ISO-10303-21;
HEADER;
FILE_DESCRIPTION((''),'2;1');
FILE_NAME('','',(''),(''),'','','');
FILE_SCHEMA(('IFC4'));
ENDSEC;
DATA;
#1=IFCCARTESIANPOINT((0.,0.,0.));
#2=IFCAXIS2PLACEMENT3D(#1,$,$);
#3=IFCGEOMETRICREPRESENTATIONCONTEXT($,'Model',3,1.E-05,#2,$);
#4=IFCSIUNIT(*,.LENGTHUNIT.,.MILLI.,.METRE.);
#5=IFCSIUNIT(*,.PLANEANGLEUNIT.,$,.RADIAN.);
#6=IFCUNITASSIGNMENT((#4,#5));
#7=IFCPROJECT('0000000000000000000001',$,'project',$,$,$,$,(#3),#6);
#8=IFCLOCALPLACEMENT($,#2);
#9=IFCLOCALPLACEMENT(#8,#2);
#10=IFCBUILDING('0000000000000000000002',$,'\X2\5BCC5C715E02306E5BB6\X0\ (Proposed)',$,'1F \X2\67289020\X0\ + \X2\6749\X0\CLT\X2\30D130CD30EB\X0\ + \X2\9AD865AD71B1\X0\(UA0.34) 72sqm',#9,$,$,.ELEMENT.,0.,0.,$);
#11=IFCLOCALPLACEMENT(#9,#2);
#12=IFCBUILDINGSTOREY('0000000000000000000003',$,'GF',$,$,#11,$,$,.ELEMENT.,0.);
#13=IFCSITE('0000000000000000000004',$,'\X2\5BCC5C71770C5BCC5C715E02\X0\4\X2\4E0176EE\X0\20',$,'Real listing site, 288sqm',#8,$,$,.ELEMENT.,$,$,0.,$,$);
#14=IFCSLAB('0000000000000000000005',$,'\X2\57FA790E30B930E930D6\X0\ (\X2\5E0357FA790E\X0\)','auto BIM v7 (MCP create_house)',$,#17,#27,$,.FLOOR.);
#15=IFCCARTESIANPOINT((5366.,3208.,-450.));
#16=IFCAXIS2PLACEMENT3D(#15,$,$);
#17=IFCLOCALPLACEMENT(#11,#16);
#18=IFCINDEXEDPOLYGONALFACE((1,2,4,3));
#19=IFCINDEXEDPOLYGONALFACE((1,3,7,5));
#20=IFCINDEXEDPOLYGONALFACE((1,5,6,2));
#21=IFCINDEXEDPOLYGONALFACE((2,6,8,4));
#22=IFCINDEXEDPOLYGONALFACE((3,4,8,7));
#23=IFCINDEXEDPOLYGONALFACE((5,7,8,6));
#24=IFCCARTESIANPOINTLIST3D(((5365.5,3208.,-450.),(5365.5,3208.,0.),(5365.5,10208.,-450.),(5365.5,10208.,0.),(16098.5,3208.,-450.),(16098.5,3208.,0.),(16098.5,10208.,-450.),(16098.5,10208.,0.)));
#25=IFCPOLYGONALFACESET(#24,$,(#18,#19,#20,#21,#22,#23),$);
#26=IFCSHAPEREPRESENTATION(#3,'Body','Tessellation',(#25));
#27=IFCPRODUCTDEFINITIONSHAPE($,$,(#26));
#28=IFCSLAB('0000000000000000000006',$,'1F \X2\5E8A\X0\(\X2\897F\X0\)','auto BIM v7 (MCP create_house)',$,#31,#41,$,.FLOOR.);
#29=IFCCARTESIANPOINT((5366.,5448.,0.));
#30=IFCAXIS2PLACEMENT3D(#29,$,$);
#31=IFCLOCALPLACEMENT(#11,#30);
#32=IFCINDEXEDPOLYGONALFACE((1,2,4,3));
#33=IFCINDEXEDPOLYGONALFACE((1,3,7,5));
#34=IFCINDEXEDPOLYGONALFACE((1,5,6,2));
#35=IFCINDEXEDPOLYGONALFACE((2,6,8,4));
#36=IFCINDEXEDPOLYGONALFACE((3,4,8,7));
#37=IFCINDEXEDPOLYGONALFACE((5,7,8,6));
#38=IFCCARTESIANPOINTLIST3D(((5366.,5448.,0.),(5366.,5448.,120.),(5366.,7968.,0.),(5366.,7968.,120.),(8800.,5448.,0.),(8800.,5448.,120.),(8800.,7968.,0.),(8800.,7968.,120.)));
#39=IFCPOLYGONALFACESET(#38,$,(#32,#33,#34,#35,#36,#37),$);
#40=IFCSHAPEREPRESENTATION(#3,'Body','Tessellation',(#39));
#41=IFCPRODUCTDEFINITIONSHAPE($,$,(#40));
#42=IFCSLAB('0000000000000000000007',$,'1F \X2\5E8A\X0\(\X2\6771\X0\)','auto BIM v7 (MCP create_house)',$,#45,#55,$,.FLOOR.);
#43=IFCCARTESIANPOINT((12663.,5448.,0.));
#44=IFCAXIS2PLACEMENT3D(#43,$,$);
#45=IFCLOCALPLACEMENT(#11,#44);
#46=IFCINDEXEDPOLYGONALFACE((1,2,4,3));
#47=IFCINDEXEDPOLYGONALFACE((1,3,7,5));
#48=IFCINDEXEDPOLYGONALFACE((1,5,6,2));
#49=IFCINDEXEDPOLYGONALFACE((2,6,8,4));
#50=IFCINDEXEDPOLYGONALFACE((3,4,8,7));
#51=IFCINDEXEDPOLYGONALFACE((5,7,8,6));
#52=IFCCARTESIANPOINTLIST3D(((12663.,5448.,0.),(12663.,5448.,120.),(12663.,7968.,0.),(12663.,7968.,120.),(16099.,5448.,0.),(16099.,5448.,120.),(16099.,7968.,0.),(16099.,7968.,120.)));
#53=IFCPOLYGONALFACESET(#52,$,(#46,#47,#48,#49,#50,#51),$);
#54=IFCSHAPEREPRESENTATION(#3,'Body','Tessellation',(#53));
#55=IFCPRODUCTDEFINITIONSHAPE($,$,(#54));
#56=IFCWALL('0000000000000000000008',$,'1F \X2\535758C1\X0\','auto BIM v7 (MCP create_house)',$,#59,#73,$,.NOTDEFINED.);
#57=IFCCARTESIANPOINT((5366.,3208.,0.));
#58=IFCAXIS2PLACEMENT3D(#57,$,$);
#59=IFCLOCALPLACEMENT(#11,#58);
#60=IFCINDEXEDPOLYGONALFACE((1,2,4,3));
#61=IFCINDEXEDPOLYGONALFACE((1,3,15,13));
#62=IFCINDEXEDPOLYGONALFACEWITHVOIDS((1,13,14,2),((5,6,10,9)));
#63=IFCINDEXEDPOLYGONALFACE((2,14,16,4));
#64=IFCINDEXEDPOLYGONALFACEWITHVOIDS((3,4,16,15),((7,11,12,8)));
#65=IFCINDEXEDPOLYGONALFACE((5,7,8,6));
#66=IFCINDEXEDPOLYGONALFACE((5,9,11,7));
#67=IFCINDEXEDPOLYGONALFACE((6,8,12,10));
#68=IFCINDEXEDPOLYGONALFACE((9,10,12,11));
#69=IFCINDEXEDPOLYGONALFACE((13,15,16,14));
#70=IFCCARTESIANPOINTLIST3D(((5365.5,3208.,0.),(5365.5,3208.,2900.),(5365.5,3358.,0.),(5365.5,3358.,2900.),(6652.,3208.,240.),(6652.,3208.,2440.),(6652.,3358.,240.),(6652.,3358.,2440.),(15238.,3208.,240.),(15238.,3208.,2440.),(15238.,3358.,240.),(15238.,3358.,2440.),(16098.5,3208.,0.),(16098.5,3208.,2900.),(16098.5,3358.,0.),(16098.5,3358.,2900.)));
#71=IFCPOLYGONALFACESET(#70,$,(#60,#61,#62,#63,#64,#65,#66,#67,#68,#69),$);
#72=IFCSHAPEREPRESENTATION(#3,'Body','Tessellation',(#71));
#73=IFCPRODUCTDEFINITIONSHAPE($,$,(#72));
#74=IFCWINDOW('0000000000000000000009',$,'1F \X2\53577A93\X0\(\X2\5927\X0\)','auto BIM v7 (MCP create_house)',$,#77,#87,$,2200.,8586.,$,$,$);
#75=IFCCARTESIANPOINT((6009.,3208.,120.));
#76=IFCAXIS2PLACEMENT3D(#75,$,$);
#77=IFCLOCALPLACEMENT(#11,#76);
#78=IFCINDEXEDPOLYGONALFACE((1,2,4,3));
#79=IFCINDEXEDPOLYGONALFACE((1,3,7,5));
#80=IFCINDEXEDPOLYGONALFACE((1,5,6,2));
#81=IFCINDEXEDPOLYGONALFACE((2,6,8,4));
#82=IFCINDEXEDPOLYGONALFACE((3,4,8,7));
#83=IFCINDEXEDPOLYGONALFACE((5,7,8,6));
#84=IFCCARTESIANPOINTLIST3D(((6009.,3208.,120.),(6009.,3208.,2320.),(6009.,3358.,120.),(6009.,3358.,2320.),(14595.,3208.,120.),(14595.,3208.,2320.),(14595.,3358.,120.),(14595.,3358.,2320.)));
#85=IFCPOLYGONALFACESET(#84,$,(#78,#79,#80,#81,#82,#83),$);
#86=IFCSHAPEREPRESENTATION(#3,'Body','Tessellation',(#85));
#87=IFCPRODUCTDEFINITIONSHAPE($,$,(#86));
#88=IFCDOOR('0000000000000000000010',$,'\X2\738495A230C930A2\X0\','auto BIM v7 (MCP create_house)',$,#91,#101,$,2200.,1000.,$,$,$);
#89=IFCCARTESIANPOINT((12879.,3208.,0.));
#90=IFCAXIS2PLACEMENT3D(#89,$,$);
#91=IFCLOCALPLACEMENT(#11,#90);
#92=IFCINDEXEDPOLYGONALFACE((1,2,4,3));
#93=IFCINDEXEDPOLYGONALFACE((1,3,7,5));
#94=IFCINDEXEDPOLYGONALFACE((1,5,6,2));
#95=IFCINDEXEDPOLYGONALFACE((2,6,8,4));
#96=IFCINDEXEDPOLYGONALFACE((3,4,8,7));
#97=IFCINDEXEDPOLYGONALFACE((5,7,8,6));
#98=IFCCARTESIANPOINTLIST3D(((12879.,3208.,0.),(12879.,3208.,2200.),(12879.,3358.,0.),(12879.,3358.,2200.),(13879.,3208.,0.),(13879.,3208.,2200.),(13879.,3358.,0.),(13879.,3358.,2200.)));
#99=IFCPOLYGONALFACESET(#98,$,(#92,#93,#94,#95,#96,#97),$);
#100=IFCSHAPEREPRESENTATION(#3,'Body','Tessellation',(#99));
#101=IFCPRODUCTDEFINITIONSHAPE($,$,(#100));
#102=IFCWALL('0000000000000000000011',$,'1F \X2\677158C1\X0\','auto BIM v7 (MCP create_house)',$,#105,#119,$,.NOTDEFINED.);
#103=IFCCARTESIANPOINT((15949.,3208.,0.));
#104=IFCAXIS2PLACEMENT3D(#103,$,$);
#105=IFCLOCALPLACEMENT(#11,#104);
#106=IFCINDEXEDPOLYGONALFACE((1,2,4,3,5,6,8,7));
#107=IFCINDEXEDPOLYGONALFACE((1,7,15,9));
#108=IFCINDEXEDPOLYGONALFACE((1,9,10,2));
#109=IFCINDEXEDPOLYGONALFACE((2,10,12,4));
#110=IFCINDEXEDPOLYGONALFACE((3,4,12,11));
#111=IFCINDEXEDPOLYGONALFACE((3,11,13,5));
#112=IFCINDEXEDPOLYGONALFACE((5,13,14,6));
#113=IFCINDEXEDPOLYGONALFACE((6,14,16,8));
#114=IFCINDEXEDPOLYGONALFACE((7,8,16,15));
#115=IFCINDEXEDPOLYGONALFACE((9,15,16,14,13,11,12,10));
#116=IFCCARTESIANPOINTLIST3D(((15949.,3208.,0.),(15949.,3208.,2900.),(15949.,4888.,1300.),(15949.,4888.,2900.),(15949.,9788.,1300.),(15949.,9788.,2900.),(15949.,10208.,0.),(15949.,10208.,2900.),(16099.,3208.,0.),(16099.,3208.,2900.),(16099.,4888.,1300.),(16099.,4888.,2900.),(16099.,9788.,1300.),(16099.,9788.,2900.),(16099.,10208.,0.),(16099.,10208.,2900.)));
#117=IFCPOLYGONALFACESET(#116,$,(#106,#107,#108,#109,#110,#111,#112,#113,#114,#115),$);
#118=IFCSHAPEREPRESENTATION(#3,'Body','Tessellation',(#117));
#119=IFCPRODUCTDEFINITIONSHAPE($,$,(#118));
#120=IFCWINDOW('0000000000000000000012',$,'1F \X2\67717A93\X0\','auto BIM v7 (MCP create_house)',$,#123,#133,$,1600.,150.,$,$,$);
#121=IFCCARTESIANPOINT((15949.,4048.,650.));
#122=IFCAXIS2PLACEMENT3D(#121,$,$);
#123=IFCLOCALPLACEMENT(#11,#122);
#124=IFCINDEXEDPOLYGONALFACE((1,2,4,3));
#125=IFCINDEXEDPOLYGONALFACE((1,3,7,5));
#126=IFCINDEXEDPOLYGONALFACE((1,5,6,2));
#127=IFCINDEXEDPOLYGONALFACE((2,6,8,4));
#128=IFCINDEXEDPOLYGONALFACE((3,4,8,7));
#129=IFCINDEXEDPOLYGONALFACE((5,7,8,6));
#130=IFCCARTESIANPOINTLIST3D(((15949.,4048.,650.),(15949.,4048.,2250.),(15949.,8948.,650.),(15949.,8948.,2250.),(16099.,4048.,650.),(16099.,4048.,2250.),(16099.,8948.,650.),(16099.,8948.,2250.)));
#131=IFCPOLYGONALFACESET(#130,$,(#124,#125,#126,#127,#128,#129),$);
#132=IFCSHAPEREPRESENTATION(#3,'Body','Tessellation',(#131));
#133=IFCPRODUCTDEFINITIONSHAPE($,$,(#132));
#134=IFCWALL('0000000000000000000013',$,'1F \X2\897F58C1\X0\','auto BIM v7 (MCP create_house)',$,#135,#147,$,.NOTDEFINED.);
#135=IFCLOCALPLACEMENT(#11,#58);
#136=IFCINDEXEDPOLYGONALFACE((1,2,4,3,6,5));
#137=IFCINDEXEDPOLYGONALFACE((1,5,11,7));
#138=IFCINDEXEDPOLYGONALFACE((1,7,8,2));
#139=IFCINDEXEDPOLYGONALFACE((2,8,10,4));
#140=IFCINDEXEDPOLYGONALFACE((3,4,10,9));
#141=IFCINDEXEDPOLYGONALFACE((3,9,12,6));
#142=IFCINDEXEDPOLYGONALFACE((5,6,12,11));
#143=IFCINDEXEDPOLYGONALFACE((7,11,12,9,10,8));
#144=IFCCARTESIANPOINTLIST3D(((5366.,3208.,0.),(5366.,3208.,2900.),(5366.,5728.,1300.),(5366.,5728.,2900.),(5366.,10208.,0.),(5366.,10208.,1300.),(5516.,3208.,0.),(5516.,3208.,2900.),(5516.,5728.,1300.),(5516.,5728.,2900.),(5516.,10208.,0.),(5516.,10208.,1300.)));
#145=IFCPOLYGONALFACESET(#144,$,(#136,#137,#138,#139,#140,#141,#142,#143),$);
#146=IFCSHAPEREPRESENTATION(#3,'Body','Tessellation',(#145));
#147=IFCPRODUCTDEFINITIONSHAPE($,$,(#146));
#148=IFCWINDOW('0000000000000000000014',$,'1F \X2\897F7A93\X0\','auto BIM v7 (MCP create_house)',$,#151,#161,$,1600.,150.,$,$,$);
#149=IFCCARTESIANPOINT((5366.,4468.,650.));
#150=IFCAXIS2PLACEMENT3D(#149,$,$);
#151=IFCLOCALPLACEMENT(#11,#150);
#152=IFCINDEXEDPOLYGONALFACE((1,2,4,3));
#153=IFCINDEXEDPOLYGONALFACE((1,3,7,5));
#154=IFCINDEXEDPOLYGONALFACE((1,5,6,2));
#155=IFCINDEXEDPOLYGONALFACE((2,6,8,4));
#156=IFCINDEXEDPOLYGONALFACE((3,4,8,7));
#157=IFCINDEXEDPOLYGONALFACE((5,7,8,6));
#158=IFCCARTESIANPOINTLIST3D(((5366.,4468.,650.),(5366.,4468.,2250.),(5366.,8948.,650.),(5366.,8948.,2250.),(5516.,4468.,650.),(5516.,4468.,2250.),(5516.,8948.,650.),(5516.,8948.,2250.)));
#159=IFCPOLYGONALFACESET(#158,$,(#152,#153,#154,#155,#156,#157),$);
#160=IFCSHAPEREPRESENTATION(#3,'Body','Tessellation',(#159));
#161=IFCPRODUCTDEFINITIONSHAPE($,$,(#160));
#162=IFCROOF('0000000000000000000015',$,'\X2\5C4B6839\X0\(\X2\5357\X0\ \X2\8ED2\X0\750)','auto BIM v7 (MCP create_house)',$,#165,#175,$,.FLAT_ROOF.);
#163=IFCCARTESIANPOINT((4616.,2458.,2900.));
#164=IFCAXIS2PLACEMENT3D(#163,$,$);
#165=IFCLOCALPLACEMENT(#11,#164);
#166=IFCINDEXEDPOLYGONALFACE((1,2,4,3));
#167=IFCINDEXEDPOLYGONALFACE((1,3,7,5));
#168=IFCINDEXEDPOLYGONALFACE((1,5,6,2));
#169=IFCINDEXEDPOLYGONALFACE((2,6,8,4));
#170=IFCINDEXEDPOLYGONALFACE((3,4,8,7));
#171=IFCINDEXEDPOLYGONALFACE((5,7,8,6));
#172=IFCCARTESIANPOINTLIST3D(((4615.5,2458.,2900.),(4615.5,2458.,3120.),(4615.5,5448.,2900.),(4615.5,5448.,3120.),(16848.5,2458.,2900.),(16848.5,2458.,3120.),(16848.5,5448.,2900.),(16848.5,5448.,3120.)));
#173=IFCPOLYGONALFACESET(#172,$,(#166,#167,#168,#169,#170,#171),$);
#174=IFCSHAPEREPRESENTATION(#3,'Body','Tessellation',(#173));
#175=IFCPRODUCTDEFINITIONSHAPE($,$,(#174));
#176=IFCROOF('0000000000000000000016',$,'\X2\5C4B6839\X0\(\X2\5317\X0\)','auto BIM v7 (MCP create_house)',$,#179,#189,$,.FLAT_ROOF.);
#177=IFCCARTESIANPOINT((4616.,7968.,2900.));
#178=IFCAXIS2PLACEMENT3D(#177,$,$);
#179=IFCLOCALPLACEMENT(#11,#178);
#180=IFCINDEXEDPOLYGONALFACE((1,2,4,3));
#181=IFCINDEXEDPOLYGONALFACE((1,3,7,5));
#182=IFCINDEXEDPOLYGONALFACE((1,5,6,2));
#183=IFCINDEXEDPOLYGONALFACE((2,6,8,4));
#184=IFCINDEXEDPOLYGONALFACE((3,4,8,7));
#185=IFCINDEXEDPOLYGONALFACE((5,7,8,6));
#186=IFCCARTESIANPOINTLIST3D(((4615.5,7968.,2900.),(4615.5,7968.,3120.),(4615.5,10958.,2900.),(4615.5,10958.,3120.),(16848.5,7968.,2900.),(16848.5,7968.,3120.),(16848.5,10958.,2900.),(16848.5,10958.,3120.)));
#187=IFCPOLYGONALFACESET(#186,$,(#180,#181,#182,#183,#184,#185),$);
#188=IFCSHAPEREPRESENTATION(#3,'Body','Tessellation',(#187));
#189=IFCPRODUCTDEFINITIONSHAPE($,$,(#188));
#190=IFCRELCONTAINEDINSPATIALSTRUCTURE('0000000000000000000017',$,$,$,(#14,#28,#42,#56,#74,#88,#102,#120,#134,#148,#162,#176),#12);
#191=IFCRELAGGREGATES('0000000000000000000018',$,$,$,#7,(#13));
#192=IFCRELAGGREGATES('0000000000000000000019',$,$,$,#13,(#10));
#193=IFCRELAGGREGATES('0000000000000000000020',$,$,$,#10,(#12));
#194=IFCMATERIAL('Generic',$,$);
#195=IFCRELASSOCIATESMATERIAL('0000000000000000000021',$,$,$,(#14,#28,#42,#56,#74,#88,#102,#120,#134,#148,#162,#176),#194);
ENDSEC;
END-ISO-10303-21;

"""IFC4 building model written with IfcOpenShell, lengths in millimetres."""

from ifc_helpers import new_model, si_unit, frame, frame_2d, origin, place, context, project, spatial, rectangle, extrude, material, element, fill, save


model = new_model("IFC4")

# Units and contexts
model_context = context("Model", 3, precision=1e-05, world=origin())
ifc_project = project(units=[si_unit("LENGTHUNIT", "METRE", prefix="MILLI"), si_unit("PLANEANGLEUNIT", "RADIAN")], contexts=[model_context])

# Site, building, storey
site_placement = place(None, origin())
site = spatial("IfcSite", under=ifc_project, at=site_placement, Name="富山県富山市4丁目20", ObjectType="Real listing site, 288sqm", CompositionType="ELEMENT", RefElevation=0.0)
building_placement = place(site_placement, origin())
building = spatial("IfcBuilding", under=site, at=building_placement, Name="富山市の家 (Proposed)", ObjectType="1F 木造 + 杉CLTパネル + 高断熱(UA0.34) 72sqm", CompositionType="ELEMENT", ElevationOfRefHeight=0.0, ElevationOfTerrain=0.0)
storey_placement = place(building_placement, origin())
storey = spatial("IfcBuildingStorey", under=building, at=storey_placement, Name="GF", CompositionType="ELEMENT", Elevation=0.0)

# Slabs
ifc_material = material(Name="Generic")
slab_1_placement = place(storey_placement, frame((5366.0, 3208.0, -450.0)))
element("IfcSlab", 1, at=slab_1_placement, inside=storey, material=ifc_material, Name="基礎スラブ (布基礎)", Description="auto BIM v7 (MCP create_house)", PredefinedType="FLOOR", context=model_context, shape_type="SweptSolid", body=[
    extrude(rectangle(XDim=10733.0, YDim=7000.0, at=frame_2d((5366.0, 3500.0))), frame((5366.0, 3208.0, -450.0)), (0.0, 0.0, 1.0), 450.0),
])
slab_2_placement = place(storey_placement, frame((5366.0, 5448.0, 0.0)))
element("IfcSlab", 2, at=slab_2_placement, inside=storey, material=ifc_material, Name="1F 床(西)", Description="auto BIM v7 (MCP create_house)", PredefinedType="FLOOR", context=model_context, shape_type="SweptSolid", body=[
    extrude(rectangle(XDim=3434.0, YDim=2520.0, at=frame_2d((1717.0, 1260.0))), frame((5366.0, 5448.0, 0.0)), (0.0, 0.0, 1.0), 120.0),
])
slab_3_placement = place(storey_placement, frame((12663.0, 5448.0, 0.0)))
element("IfcSlab", 3, at=slab_3_placement, inside=storey, material=ifc_material, Name="1F 床(東)", Description="auto BIM v7 (MCP create_house)", PredefinedType="FLOOR", context=model_context, shape_type="SweptSolid", body=[
    extrude(rectangle(XDim=3436.0, YDim=2520.0, at=frame_2d((1718.0, 1260.0))), frame((12663.0, 5448.0, 0.0)), (0.0, 0.0, 1.0), 120.0),
])

# Wall, openings, window, door
wall_1_placement = place(storey_placement, frame((5366.0, 3208.0, 0.0)))
wall_1 = element("IfcWall", 4, at=wall_1_placement, inside=storey, material=ifc_material, Name="1F 南壁", Description="auto BIM v7 (MCP create_house)", PredefinedType="NOTDEFINED", context=model_context, shape_type="SweptSolid", body=[
    extrude(rectangle(XDim=10733.0, YDim=150.0, at=frame_2d((5366.0, 75.0))), frame((5366.0, 3208.0, 0.0)), (0.0, 0.0, 1.0), 2900.0),
])
opening_1_placement = place(storey_placement, frame((6009.0, 3208.0, 120.0)))
opening_1 = element("IfcOpeningElement", 5, at=opening_1_placement, cuts=wall_1, PredefinedType="NOTDEFINED", context=model_context, shape_type="SweptSolid", body=[
    extrude(rectangle(XDim=8586.0, YDim=150.0, at=frame_2d((4293.0, 75.0))), frame((6009.0, 3208.0, 120.0)), (0.0, 0.0, 1.0), 2200.0),
])
opening_2_placement = place(storey_placement, frame((12879.0, 3208.0, 0.0)))
opening_2 = element("IfcOpeningElement", 6, at=opening_2_placement, cuts=wall_1, PredefinedType="NOTDEFINED", context=model_context, shape_type="SweptSolid", body=[
    extrude(rectangle(XDim=1000.0, YDim=150.0, at=frame_2d((500.0, 75.0))), frame((12879.0, 3208.0, 0.0)), (0.0, 0.0, 1.0), 2200.0),
])
window_1_placement = place(storey_placement, frame((6009.0, 3208.0, 120.0)))
window_1 = element("IfcWindow", 7, at=window_1_placement, inside=storey, material=ifc_material, Name="1F 南窓(大)", Description="auto BIM v7 (MCP create_house)", OverallHeight=2200.0, OverallWidth=8586.0, context=model_context, shape_type="SweptSolid", body=[
    extrude(rectangle(XDim=8586.0, YDim=150.0, at=frame_2d((4293.0, 75.0))), frame((6009.0, 3208.0, 120.0)), (0.0, 0.0, 1.0), 2200.0),
])
fill(opening_1, window_1)
door_placement = place(storey_placement, frame((12879.0, 3208.0, 0.0)))
door = element("IfcDoor", 8, at=door_placement, inside=storey, material=ifc_material, Name="玄関ドア", Description="auto BIM v7 (MCP create_house)", OverallHeight=2200.0, OverallWidth=1000.0, context=model_context, shape_type="SweptSolid", body=[
    extrude(rectangle(XDim=1000.0, YDim=150.0, at=frame_2d((500.0, 75.0))), frame((12879.0, 3208.0, 0.0)), (0.0, 0.0, 1.0), 2200.0),
])
fill(opening_2, door)

# Walls, openings, windows
wall_2_placement = place(storey_placement, frame((15949.0, 3208.0, 0.0)))
wall_2 = element("IfcWall", 9, at=wall_2_placement, inside=storey, material=ifc_material, Name="1F 東壁", Description="auto BIM v7 (MCP create_house)", PredefinedType="NOTDEFINED", context=model_context, shape_type="SweptSolid", body=[
    extrude(rectangle(XDim=150.0, YDim=7000.0, at=frame_2d((75.0, 3500.0))), frame((15949.0, 3208.0, 0.0)), (0.0, 0.0, 1.0), 2900.0),
])
opening_3_placement = place(storey_placement, frame((15949.0, 4048.0, 650.0)))
opening_3 = element("IfcOpeningElement", 10, at=opening_3_placement, cuts=wall_2, PredefinedType="NOTDEFINED", context=model_context, shape_type="SweptSolid", body=[
    extrude(rectangle(XDim=150.0, YDim=4900.0, at=frame_2d((75.0, 2450.0))), frame((15949.0, 4048.0, 650.0)), (0.0, 0.0, 1.0), 1600.0),
])
window_2_placement = place(storey_placement, frame((15949.0, 4048.0, 650.0)))
window_2 = element("IfcWindow", 11, at=window_2_placement, inside=storey, material=ifc_material, Name="1F 東窓", Description="auto BIM v7 (MCP create_house)", OverallHeight=1600.0, OverallWidth=150.0, context=model_context, shape_type="SweptSolid", body=[
    extrude(rectangle(XDim=150.0, YDim=4900.0, at=frame_2d((75.0, 2450.0))), frame((15949.0, 4048.0, 650.0)), (0.0, 0.0, 1.0), 1600.0),
])
fill(opening_3, window_2)
wall_3_placement = place(storey_placement, frame((5366.0, 3208.0, 0.0)))
wall_3 = element("IfcWall", 12, at=wall_3_placement, inside=storey, material=ifc_material, Name="1F 西壁", Description="auto BIM v7 (MCP create_house)", PredefinedType="NOTDEFINED", context=model_context, shape_type="SweptSolid", body=[
    extrude(rectangle(XDim=150.0, YDim=7000.0, at=frame_2d((75.0, 3500.0))), frame((5366.0, 3208.0, 0.0)), (0.0, 0.0, 1.0), 2900.0),
])
opening_4_placement = place(storey_placement, frame((5366.0, 4468.0, 650.0)))
opening_4 = element("IfcOpeningElement", 13, at=opening_4_placement, cuts=wall_3, PredefinedType="NOTDEFINED", context=model_context, shape_type="SweptSolid", body=[
    extrude(rectangle(XDim=150.0, YDim=4480.0, at=frame_2d((75.0, 2240.0))), frame((5366.0, 4468.0, 650.0)), (0.0, 0.0, 1.0), 1600.0),
])
window_3_placement = place(storey_placement, frame((5366.0, 4468.0, 650.0)))
window_3 = element("IfcWindow", 14, at=window_3_placement, inside=storey, material=ifc_material, Name="1F 西窓", Description="auto BIM v7 (MCP create_house)", OverallHeight=1600.0, OverallWidth=150.0, context=model_context, shape_type="SweptSolid", body=[
    extrude(rectangle(XDim=150.0, YDim=4480.0, at=frame_2d((75.0, 2240.0))), frame((5366.0, 4468.0, 650.0)), (0.0, 0.0, 1.0), 1600.0),
])
fill(opening_4, window_3)

# Roofs
roof_1_placement = place(storey_placement, frame((4616.0, 2458.0, 2900.0)))
element("IfcRoof", 15, at=roof_1_placement, inside=storey, material=ifc_material, Name="屋根(南 軒750)", Description="auto BIM v7 (MCP create_house)", PredefinedType="FLAT_ROOF", context=model_context, shape_type="SweptSolid", body=[
    extrude(rectangle(XDim=12233.0, YDim=2990.0, at=frame_2d((6116.0, 1495.0))), frame((4616.0, 2458.0, 2900.0)), (0.0, 0.0, 1.0), 220.0),
])
roof_2_placement = place(storey_placement, frame((4616.0, 7968.0, 2900.0)))
element("IfcRoof", 16, at=roof_2_placement, inside=storey, material=ifc_material, Name="屋根(北)", Description="auto BIM v7 (MCP create_house)", PredefinedType="FLAT_ROOF", context=model_context, shape_type="SweptSolid", body=[
    extrude(rectangle(XDim=12233.0, YDim=2990.0, at=frame_2d((6116.0, 1495.0))), frame((4616.0, 7968.0, 2900.0)), (0.0, 0.0, 1.0), 220.0),
])

save(model, "model.ifc")
